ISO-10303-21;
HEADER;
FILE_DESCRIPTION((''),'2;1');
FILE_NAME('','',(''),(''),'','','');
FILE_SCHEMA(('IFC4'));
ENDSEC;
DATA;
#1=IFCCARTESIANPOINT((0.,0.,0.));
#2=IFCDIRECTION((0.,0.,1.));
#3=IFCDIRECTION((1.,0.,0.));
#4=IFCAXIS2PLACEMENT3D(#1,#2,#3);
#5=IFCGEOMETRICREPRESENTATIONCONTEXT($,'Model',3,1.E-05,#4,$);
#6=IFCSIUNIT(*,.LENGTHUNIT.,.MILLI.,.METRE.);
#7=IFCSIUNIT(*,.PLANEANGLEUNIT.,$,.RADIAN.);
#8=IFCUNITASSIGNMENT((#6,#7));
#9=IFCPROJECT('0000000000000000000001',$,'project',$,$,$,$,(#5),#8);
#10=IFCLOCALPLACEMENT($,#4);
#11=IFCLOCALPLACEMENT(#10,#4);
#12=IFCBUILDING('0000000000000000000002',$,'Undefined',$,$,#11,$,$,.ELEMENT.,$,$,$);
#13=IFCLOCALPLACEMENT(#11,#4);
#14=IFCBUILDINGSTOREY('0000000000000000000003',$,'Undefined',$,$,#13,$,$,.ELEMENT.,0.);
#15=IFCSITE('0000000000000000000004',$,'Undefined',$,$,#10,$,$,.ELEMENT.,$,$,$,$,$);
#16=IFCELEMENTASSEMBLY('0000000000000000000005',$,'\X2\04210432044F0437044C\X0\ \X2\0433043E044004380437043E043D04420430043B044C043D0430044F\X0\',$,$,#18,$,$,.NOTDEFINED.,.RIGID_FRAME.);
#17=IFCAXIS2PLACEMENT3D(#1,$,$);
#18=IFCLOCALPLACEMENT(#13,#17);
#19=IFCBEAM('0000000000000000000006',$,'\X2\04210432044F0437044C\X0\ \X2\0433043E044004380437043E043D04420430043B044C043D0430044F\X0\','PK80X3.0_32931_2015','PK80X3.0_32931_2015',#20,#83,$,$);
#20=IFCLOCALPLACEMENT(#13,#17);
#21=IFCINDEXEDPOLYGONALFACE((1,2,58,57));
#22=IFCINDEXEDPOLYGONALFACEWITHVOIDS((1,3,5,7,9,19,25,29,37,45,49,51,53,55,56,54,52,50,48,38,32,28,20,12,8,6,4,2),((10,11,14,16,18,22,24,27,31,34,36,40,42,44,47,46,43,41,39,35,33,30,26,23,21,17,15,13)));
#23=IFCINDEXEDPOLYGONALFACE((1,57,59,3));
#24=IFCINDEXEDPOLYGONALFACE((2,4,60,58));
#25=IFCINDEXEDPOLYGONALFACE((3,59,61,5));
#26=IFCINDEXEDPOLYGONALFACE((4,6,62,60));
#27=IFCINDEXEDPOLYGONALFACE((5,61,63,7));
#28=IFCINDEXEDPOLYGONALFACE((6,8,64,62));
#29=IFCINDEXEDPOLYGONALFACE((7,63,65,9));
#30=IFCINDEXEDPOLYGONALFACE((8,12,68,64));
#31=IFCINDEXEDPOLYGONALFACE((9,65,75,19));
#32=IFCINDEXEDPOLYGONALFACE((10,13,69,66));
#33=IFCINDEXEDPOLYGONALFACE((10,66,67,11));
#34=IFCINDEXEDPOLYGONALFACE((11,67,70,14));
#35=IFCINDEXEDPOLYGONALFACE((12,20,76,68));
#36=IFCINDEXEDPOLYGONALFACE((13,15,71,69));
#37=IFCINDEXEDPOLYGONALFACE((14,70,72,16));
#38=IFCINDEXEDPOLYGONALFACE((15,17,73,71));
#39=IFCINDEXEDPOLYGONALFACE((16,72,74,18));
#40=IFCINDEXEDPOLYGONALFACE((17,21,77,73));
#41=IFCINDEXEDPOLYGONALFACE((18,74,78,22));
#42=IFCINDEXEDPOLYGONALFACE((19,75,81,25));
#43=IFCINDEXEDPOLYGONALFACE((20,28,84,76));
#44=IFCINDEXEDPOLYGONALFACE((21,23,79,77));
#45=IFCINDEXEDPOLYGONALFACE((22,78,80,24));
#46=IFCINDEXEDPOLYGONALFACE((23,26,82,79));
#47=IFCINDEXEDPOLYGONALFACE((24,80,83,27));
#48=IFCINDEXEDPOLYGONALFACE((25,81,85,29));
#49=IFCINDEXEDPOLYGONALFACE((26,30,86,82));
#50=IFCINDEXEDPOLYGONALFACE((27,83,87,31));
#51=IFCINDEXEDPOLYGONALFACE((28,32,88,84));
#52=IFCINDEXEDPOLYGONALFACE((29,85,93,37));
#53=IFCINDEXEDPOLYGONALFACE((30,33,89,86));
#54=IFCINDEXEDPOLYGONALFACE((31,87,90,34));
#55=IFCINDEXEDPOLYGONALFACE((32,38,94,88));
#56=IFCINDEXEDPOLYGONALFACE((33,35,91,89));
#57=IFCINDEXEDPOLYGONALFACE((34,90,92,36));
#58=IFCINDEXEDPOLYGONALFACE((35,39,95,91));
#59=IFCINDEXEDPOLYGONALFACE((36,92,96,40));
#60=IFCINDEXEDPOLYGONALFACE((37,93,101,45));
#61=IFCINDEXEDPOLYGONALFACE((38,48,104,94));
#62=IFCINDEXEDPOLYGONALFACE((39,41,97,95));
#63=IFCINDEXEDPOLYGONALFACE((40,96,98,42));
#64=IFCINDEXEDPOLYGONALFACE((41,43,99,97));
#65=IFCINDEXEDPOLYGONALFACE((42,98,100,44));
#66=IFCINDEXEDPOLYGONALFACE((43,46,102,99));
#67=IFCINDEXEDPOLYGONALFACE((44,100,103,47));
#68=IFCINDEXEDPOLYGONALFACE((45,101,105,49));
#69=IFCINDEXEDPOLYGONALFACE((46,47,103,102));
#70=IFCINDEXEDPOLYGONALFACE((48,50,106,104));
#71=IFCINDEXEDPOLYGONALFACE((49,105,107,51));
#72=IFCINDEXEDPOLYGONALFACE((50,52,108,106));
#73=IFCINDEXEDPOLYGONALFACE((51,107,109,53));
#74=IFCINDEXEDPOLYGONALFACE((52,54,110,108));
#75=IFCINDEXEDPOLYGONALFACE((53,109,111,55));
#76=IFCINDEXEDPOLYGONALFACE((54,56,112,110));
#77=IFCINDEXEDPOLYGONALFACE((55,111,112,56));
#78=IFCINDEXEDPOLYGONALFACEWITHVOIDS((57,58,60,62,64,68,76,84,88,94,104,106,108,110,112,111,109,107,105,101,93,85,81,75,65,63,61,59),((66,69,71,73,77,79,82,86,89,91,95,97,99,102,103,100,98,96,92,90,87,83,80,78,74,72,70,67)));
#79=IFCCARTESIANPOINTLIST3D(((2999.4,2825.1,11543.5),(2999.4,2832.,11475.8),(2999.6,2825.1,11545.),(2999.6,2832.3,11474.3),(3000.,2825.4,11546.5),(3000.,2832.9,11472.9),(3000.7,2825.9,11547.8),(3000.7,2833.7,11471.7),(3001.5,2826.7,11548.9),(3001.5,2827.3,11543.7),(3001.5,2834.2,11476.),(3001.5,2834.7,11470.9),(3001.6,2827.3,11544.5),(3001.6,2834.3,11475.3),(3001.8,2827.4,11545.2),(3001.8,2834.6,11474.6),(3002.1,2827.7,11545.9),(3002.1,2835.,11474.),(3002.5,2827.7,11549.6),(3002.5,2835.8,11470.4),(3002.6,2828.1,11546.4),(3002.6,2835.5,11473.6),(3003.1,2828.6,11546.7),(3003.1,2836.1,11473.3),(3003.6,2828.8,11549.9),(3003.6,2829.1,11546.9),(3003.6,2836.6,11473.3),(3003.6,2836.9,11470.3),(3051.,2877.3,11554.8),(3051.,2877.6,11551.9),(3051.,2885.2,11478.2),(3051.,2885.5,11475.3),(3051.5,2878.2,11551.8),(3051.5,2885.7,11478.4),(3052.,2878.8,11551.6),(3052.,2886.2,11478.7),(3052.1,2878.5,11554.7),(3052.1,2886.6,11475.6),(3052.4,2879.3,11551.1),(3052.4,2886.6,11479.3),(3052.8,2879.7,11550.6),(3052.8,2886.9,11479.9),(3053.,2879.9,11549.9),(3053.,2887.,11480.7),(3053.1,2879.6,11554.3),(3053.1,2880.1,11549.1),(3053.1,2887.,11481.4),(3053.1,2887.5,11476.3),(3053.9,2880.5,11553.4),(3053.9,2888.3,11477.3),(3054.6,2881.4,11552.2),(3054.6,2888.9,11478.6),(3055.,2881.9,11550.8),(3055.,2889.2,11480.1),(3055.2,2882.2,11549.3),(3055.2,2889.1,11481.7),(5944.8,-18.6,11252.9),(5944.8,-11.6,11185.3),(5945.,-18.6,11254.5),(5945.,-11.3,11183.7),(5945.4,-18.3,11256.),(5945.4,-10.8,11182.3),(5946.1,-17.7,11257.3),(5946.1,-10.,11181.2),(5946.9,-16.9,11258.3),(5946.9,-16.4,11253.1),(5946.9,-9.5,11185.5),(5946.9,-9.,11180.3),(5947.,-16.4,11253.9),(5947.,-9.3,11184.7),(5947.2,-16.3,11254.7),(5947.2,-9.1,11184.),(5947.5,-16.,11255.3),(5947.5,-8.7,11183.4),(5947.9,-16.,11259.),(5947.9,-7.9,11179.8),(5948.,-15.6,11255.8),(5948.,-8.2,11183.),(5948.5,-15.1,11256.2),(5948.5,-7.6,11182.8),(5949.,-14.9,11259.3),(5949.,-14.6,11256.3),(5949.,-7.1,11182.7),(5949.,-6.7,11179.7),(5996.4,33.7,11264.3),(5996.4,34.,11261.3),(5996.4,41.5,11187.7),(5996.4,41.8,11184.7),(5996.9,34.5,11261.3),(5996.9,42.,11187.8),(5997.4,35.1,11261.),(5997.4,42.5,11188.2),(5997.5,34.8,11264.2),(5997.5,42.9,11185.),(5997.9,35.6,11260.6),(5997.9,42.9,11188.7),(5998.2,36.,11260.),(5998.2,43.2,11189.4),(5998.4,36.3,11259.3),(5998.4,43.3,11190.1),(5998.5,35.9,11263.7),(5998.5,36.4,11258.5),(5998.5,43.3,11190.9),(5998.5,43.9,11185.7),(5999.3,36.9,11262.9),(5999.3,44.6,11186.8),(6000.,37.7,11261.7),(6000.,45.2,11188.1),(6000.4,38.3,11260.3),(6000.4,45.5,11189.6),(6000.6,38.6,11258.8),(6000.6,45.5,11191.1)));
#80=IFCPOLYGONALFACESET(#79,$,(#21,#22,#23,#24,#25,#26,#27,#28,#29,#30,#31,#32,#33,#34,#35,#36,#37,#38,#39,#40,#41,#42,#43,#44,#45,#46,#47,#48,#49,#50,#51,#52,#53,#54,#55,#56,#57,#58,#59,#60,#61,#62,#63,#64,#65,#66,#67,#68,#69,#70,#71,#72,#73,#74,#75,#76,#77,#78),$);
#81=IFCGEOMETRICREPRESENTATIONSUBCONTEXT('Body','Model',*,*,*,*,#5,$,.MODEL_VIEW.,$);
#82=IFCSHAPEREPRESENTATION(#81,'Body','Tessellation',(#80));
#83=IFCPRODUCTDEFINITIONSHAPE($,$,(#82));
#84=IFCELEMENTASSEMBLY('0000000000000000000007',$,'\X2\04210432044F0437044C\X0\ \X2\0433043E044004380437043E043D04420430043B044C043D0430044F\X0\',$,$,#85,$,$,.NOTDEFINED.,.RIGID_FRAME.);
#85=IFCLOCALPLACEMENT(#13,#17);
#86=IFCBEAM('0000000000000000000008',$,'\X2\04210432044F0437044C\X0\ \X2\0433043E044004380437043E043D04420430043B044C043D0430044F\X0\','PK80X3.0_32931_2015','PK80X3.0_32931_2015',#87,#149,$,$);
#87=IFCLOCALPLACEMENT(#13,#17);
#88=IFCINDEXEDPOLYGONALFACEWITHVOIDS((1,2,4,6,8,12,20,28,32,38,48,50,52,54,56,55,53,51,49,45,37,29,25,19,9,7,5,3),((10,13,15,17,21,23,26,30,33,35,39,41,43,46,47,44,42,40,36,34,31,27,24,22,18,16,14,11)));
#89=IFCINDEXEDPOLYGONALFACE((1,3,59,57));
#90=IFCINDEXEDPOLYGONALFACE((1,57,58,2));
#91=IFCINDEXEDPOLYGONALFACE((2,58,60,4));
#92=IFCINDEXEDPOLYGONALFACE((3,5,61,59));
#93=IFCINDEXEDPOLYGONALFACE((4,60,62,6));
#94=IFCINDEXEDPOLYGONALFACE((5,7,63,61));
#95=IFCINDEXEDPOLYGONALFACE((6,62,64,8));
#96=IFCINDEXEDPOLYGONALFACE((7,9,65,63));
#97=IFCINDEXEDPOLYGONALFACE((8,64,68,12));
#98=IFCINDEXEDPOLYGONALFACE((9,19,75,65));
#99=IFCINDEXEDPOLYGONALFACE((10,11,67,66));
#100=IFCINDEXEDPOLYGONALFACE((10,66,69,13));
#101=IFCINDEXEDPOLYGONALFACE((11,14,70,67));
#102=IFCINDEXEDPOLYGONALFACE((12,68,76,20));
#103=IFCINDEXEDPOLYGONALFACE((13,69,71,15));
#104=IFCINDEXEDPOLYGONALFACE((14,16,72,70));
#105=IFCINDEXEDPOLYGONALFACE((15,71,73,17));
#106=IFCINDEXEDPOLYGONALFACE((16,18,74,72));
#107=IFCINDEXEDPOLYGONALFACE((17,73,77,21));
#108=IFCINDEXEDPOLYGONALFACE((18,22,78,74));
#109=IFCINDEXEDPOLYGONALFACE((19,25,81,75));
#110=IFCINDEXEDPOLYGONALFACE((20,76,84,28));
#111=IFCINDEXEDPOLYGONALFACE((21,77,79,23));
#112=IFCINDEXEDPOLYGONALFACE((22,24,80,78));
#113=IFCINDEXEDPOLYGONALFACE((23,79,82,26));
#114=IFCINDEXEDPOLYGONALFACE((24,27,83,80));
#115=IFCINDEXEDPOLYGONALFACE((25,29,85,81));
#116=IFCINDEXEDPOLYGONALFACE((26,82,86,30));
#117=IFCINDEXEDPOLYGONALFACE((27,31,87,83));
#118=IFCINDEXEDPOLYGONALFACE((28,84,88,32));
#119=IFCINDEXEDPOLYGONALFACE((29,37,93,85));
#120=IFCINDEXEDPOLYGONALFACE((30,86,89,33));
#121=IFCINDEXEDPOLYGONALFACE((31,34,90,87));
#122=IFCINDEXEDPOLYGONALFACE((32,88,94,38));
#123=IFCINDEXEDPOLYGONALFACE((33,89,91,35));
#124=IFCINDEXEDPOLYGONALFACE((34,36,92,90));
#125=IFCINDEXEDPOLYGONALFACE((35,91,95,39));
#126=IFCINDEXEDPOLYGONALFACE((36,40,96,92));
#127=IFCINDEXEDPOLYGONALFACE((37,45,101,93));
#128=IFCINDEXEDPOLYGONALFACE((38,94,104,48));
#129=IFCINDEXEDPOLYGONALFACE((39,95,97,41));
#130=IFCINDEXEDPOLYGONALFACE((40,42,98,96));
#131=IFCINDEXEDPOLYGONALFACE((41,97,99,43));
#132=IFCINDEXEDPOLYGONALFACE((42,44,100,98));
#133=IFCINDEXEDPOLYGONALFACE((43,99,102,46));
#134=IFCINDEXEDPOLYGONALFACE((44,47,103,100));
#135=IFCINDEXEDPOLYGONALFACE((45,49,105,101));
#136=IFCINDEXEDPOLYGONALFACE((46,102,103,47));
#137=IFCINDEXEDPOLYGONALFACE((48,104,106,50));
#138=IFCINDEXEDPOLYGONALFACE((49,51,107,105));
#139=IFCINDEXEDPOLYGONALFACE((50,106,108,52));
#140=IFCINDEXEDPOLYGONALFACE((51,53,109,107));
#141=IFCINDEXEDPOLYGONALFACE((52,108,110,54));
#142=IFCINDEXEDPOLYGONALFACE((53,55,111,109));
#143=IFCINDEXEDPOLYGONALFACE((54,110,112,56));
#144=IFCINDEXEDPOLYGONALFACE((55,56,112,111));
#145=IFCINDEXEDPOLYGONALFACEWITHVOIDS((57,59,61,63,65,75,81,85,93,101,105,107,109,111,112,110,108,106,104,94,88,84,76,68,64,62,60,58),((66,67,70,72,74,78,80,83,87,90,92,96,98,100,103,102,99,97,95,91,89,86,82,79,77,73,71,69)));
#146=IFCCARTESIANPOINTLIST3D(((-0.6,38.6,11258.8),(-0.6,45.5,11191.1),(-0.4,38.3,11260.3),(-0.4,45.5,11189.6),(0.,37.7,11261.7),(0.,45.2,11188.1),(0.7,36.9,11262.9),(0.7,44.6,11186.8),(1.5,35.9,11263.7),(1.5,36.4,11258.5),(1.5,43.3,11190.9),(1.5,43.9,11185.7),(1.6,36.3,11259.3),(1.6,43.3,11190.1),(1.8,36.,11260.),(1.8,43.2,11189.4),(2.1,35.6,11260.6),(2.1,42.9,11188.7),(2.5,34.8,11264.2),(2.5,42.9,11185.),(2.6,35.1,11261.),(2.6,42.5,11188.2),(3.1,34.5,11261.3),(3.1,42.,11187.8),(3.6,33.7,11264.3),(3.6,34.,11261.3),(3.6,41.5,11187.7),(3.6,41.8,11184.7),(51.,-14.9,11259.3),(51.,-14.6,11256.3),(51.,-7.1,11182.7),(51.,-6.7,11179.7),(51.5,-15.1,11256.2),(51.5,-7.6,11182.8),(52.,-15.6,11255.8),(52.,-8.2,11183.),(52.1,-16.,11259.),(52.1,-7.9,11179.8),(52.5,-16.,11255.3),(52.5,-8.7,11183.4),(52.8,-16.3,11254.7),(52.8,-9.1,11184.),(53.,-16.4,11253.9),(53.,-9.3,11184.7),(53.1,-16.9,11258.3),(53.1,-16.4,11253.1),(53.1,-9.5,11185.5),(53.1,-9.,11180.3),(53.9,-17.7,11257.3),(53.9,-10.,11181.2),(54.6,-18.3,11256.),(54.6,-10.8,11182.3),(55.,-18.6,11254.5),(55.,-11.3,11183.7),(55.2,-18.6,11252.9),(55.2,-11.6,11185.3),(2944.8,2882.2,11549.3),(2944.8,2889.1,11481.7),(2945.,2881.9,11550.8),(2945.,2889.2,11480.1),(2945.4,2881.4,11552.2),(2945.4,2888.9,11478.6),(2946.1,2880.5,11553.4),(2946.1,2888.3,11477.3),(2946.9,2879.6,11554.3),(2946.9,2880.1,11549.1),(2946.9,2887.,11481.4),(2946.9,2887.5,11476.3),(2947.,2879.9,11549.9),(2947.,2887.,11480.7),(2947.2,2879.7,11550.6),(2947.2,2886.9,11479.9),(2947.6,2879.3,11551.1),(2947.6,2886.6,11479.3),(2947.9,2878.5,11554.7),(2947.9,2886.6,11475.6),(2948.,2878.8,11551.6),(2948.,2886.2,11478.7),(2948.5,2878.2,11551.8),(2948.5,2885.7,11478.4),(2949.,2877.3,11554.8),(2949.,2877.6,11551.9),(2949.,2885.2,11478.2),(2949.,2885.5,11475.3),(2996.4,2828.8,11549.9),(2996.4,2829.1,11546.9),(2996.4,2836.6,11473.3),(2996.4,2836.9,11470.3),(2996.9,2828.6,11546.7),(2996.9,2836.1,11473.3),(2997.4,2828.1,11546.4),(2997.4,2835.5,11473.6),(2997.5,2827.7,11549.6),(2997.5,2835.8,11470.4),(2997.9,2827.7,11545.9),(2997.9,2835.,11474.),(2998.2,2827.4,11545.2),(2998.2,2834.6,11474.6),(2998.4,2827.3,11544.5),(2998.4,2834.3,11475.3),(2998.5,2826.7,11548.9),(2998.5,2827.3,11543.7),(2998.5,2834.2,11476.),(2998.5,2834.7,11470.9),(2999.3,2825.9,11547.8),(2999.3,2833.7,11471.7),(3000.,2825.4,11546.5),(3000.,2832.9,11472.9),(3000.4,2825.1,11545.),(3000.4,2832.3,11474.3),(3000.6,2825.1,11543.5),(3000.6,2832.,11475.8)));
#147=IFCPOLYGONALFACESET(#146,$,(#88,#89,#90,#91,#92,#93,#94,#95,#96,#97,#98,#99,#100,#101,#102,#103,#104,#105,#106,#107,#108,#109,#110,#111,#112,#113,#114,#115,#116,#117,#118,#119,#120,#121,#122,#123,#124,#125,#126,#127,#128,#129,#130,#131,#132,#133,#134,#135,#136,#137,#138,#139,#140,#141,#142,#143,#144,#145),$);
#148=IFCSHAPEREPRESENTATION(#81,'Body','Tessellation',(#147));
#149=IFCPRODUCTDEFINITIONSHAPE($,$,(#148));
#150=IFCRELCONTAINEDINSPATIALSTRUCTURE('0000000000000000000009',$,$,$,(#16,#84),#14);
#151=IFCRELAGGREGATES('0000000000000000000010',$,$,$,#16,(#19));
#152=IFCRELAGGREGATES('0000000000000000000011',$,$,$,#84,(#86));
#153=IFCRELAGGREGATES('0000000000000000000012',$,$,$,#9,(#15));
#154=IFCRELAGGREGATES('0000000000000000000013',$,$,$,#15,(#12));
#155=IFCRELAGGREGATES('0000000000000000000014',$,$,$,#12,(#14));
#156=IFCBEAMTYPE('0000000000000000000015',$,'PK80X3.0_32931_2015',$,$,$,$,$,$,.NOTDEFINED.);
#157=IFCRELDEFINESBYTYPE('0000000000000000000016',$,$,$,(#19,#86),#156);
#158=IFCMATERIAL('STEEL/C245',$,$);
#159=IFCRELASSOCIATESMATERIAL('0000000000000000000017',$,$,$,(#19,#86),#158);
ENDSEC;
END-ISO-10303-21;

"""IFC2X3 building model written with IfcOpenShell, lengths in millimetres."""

from ifc_helpers import new_model, si_unit, frame, origin_with_axes, origin_2d_with_axis, place, context, subcontext, project, spatial, hollow_rectangle, extrude, material, type_object, element, aggregate, save


model = new_model("IFC2X3")

# Units and contexts
model_context = context("Model", 3, precision=1e-05, world=origin_with_axes())
body_context = subcontext(model_context, "Body", "Model", "MODEL_VIEW")
ifc_project = project(units=[si_unit("LENGTHUNIT", "METRE", prefix="MILLI"), si_unit("PLANEANGLEUNIT", "RADIAN")], contexts=[model_context])

# Site, building, storey
site_placement = place(None, origin_with_axes())
site = spatial("IfcSite", under=ifc_project, at=site_placement, Name="Undefined", CompositionType="ELEMENT")
building_placement = place(site_placement, origin_with_axes())
building = spatial("IfcBuilding", under=site, at=building_placement, Name="Undefined", CompositionType="ELEMENT")
storey_placement = place(building_placement, origin_with_axes())
storey = spatial("IfcBuildingStorey", under=building, at=storey_placement, Name="Undefined", CompositionType="ELEMENT", Elevation=0.0)

# Element assemblies, beams
ifc_material_1 = material(Name="STEEL/C245")
beam_type_1 = type_object("IfcBeamType", Name="PK80X3.0_32931_2015", PredefinedType="NOTDEFINED")
assembly_1_placement = place(storey_placement, origin_with_axes())
assembly_1 = element("IfcElementAssembly", 1, at=assembly_1_placement, inside=storey, Name="Связь горизонтальная", AssemblyPlace="NOTDEFINED", PredefinedType="RIGID_FRAME")
beam_1_placement = place(assembly_1_placement, frame((5972.7, 13.5, 11222.0), z_axis=(0.0, -0.101645, 0.994821), x_axis=(-0.717617, 0.69283, 0.070789)))
beam_1 = element("IfcBeam", 2, at=beam_1_placement, type_object=beam_type_1, material=ifc_material_1, Name="Связь горизонтальная", Description="PK80X3.0_32931_2015", ObjectType="PK80X3.0_32931_2015", context=body_context, shape_type="SweptSolid", body=[
    extrude(hollow_rectangle(XDim=80.0, YDim=80.0, WallThickness=3.0, InnerFilletRadius=3.0, OuterFilletRadius=6.0, at=origin_2d_with_axis()), frame((4104.4, 0.0, 0.0), z_axis=(-1.0, 0.0, 0.0), x_axis=(0.0, -1.0, 0.0)), (0.0, 0.0, 1.0), 4104.4),
])
aggregate(assembly_1, [beam_1])
assembly_2_placement = place(storey_placement, origin_with_axes())
assembly_2 = element("IfcElementAssembly", 3, at=assembly_2_placement, inside=storey, Name="Связь горизонтальная", AssemblyPlace="NOTDEFINED", PredefinedType="RIGID_FRAME")
beam_2_placement = place(assembly_2_placement, frame((27.3, 13.5, 11222.0), z_axis=(0.0, -0.101645, 0.994821), x_axis=(0.717617, 0.69283, 0.070789)))
beam_2 = element("IfcBeam", 4, at=beam_2_placement, type_object=beam_type_1, material=ifc_material_1, Name="Связь горизонтальная", Description="PK80X3.0_32931_2015", ObjectType="PK80X3.0_32931_2015", context=body_context, shape_type="SweptSolid", body=[
    extrude(hollow_rectangle(XDim=80.0, YDim=80.0, WallThickness=3.0, InnerFilletRadius=3.0, OuterFilletRadius=6.0, at=origin_2d_with_axis()), frame((4104.4, 0.0, 0.0), z_axis=(-1.0, 0.0, 0.0), x_axis=(0.0, -1.0, 0.0)), (0.0, 0.0, 1.0), 4104.4),
])
aggregate(assembly_2, [beam_2])

save(model, "model.ifc")
